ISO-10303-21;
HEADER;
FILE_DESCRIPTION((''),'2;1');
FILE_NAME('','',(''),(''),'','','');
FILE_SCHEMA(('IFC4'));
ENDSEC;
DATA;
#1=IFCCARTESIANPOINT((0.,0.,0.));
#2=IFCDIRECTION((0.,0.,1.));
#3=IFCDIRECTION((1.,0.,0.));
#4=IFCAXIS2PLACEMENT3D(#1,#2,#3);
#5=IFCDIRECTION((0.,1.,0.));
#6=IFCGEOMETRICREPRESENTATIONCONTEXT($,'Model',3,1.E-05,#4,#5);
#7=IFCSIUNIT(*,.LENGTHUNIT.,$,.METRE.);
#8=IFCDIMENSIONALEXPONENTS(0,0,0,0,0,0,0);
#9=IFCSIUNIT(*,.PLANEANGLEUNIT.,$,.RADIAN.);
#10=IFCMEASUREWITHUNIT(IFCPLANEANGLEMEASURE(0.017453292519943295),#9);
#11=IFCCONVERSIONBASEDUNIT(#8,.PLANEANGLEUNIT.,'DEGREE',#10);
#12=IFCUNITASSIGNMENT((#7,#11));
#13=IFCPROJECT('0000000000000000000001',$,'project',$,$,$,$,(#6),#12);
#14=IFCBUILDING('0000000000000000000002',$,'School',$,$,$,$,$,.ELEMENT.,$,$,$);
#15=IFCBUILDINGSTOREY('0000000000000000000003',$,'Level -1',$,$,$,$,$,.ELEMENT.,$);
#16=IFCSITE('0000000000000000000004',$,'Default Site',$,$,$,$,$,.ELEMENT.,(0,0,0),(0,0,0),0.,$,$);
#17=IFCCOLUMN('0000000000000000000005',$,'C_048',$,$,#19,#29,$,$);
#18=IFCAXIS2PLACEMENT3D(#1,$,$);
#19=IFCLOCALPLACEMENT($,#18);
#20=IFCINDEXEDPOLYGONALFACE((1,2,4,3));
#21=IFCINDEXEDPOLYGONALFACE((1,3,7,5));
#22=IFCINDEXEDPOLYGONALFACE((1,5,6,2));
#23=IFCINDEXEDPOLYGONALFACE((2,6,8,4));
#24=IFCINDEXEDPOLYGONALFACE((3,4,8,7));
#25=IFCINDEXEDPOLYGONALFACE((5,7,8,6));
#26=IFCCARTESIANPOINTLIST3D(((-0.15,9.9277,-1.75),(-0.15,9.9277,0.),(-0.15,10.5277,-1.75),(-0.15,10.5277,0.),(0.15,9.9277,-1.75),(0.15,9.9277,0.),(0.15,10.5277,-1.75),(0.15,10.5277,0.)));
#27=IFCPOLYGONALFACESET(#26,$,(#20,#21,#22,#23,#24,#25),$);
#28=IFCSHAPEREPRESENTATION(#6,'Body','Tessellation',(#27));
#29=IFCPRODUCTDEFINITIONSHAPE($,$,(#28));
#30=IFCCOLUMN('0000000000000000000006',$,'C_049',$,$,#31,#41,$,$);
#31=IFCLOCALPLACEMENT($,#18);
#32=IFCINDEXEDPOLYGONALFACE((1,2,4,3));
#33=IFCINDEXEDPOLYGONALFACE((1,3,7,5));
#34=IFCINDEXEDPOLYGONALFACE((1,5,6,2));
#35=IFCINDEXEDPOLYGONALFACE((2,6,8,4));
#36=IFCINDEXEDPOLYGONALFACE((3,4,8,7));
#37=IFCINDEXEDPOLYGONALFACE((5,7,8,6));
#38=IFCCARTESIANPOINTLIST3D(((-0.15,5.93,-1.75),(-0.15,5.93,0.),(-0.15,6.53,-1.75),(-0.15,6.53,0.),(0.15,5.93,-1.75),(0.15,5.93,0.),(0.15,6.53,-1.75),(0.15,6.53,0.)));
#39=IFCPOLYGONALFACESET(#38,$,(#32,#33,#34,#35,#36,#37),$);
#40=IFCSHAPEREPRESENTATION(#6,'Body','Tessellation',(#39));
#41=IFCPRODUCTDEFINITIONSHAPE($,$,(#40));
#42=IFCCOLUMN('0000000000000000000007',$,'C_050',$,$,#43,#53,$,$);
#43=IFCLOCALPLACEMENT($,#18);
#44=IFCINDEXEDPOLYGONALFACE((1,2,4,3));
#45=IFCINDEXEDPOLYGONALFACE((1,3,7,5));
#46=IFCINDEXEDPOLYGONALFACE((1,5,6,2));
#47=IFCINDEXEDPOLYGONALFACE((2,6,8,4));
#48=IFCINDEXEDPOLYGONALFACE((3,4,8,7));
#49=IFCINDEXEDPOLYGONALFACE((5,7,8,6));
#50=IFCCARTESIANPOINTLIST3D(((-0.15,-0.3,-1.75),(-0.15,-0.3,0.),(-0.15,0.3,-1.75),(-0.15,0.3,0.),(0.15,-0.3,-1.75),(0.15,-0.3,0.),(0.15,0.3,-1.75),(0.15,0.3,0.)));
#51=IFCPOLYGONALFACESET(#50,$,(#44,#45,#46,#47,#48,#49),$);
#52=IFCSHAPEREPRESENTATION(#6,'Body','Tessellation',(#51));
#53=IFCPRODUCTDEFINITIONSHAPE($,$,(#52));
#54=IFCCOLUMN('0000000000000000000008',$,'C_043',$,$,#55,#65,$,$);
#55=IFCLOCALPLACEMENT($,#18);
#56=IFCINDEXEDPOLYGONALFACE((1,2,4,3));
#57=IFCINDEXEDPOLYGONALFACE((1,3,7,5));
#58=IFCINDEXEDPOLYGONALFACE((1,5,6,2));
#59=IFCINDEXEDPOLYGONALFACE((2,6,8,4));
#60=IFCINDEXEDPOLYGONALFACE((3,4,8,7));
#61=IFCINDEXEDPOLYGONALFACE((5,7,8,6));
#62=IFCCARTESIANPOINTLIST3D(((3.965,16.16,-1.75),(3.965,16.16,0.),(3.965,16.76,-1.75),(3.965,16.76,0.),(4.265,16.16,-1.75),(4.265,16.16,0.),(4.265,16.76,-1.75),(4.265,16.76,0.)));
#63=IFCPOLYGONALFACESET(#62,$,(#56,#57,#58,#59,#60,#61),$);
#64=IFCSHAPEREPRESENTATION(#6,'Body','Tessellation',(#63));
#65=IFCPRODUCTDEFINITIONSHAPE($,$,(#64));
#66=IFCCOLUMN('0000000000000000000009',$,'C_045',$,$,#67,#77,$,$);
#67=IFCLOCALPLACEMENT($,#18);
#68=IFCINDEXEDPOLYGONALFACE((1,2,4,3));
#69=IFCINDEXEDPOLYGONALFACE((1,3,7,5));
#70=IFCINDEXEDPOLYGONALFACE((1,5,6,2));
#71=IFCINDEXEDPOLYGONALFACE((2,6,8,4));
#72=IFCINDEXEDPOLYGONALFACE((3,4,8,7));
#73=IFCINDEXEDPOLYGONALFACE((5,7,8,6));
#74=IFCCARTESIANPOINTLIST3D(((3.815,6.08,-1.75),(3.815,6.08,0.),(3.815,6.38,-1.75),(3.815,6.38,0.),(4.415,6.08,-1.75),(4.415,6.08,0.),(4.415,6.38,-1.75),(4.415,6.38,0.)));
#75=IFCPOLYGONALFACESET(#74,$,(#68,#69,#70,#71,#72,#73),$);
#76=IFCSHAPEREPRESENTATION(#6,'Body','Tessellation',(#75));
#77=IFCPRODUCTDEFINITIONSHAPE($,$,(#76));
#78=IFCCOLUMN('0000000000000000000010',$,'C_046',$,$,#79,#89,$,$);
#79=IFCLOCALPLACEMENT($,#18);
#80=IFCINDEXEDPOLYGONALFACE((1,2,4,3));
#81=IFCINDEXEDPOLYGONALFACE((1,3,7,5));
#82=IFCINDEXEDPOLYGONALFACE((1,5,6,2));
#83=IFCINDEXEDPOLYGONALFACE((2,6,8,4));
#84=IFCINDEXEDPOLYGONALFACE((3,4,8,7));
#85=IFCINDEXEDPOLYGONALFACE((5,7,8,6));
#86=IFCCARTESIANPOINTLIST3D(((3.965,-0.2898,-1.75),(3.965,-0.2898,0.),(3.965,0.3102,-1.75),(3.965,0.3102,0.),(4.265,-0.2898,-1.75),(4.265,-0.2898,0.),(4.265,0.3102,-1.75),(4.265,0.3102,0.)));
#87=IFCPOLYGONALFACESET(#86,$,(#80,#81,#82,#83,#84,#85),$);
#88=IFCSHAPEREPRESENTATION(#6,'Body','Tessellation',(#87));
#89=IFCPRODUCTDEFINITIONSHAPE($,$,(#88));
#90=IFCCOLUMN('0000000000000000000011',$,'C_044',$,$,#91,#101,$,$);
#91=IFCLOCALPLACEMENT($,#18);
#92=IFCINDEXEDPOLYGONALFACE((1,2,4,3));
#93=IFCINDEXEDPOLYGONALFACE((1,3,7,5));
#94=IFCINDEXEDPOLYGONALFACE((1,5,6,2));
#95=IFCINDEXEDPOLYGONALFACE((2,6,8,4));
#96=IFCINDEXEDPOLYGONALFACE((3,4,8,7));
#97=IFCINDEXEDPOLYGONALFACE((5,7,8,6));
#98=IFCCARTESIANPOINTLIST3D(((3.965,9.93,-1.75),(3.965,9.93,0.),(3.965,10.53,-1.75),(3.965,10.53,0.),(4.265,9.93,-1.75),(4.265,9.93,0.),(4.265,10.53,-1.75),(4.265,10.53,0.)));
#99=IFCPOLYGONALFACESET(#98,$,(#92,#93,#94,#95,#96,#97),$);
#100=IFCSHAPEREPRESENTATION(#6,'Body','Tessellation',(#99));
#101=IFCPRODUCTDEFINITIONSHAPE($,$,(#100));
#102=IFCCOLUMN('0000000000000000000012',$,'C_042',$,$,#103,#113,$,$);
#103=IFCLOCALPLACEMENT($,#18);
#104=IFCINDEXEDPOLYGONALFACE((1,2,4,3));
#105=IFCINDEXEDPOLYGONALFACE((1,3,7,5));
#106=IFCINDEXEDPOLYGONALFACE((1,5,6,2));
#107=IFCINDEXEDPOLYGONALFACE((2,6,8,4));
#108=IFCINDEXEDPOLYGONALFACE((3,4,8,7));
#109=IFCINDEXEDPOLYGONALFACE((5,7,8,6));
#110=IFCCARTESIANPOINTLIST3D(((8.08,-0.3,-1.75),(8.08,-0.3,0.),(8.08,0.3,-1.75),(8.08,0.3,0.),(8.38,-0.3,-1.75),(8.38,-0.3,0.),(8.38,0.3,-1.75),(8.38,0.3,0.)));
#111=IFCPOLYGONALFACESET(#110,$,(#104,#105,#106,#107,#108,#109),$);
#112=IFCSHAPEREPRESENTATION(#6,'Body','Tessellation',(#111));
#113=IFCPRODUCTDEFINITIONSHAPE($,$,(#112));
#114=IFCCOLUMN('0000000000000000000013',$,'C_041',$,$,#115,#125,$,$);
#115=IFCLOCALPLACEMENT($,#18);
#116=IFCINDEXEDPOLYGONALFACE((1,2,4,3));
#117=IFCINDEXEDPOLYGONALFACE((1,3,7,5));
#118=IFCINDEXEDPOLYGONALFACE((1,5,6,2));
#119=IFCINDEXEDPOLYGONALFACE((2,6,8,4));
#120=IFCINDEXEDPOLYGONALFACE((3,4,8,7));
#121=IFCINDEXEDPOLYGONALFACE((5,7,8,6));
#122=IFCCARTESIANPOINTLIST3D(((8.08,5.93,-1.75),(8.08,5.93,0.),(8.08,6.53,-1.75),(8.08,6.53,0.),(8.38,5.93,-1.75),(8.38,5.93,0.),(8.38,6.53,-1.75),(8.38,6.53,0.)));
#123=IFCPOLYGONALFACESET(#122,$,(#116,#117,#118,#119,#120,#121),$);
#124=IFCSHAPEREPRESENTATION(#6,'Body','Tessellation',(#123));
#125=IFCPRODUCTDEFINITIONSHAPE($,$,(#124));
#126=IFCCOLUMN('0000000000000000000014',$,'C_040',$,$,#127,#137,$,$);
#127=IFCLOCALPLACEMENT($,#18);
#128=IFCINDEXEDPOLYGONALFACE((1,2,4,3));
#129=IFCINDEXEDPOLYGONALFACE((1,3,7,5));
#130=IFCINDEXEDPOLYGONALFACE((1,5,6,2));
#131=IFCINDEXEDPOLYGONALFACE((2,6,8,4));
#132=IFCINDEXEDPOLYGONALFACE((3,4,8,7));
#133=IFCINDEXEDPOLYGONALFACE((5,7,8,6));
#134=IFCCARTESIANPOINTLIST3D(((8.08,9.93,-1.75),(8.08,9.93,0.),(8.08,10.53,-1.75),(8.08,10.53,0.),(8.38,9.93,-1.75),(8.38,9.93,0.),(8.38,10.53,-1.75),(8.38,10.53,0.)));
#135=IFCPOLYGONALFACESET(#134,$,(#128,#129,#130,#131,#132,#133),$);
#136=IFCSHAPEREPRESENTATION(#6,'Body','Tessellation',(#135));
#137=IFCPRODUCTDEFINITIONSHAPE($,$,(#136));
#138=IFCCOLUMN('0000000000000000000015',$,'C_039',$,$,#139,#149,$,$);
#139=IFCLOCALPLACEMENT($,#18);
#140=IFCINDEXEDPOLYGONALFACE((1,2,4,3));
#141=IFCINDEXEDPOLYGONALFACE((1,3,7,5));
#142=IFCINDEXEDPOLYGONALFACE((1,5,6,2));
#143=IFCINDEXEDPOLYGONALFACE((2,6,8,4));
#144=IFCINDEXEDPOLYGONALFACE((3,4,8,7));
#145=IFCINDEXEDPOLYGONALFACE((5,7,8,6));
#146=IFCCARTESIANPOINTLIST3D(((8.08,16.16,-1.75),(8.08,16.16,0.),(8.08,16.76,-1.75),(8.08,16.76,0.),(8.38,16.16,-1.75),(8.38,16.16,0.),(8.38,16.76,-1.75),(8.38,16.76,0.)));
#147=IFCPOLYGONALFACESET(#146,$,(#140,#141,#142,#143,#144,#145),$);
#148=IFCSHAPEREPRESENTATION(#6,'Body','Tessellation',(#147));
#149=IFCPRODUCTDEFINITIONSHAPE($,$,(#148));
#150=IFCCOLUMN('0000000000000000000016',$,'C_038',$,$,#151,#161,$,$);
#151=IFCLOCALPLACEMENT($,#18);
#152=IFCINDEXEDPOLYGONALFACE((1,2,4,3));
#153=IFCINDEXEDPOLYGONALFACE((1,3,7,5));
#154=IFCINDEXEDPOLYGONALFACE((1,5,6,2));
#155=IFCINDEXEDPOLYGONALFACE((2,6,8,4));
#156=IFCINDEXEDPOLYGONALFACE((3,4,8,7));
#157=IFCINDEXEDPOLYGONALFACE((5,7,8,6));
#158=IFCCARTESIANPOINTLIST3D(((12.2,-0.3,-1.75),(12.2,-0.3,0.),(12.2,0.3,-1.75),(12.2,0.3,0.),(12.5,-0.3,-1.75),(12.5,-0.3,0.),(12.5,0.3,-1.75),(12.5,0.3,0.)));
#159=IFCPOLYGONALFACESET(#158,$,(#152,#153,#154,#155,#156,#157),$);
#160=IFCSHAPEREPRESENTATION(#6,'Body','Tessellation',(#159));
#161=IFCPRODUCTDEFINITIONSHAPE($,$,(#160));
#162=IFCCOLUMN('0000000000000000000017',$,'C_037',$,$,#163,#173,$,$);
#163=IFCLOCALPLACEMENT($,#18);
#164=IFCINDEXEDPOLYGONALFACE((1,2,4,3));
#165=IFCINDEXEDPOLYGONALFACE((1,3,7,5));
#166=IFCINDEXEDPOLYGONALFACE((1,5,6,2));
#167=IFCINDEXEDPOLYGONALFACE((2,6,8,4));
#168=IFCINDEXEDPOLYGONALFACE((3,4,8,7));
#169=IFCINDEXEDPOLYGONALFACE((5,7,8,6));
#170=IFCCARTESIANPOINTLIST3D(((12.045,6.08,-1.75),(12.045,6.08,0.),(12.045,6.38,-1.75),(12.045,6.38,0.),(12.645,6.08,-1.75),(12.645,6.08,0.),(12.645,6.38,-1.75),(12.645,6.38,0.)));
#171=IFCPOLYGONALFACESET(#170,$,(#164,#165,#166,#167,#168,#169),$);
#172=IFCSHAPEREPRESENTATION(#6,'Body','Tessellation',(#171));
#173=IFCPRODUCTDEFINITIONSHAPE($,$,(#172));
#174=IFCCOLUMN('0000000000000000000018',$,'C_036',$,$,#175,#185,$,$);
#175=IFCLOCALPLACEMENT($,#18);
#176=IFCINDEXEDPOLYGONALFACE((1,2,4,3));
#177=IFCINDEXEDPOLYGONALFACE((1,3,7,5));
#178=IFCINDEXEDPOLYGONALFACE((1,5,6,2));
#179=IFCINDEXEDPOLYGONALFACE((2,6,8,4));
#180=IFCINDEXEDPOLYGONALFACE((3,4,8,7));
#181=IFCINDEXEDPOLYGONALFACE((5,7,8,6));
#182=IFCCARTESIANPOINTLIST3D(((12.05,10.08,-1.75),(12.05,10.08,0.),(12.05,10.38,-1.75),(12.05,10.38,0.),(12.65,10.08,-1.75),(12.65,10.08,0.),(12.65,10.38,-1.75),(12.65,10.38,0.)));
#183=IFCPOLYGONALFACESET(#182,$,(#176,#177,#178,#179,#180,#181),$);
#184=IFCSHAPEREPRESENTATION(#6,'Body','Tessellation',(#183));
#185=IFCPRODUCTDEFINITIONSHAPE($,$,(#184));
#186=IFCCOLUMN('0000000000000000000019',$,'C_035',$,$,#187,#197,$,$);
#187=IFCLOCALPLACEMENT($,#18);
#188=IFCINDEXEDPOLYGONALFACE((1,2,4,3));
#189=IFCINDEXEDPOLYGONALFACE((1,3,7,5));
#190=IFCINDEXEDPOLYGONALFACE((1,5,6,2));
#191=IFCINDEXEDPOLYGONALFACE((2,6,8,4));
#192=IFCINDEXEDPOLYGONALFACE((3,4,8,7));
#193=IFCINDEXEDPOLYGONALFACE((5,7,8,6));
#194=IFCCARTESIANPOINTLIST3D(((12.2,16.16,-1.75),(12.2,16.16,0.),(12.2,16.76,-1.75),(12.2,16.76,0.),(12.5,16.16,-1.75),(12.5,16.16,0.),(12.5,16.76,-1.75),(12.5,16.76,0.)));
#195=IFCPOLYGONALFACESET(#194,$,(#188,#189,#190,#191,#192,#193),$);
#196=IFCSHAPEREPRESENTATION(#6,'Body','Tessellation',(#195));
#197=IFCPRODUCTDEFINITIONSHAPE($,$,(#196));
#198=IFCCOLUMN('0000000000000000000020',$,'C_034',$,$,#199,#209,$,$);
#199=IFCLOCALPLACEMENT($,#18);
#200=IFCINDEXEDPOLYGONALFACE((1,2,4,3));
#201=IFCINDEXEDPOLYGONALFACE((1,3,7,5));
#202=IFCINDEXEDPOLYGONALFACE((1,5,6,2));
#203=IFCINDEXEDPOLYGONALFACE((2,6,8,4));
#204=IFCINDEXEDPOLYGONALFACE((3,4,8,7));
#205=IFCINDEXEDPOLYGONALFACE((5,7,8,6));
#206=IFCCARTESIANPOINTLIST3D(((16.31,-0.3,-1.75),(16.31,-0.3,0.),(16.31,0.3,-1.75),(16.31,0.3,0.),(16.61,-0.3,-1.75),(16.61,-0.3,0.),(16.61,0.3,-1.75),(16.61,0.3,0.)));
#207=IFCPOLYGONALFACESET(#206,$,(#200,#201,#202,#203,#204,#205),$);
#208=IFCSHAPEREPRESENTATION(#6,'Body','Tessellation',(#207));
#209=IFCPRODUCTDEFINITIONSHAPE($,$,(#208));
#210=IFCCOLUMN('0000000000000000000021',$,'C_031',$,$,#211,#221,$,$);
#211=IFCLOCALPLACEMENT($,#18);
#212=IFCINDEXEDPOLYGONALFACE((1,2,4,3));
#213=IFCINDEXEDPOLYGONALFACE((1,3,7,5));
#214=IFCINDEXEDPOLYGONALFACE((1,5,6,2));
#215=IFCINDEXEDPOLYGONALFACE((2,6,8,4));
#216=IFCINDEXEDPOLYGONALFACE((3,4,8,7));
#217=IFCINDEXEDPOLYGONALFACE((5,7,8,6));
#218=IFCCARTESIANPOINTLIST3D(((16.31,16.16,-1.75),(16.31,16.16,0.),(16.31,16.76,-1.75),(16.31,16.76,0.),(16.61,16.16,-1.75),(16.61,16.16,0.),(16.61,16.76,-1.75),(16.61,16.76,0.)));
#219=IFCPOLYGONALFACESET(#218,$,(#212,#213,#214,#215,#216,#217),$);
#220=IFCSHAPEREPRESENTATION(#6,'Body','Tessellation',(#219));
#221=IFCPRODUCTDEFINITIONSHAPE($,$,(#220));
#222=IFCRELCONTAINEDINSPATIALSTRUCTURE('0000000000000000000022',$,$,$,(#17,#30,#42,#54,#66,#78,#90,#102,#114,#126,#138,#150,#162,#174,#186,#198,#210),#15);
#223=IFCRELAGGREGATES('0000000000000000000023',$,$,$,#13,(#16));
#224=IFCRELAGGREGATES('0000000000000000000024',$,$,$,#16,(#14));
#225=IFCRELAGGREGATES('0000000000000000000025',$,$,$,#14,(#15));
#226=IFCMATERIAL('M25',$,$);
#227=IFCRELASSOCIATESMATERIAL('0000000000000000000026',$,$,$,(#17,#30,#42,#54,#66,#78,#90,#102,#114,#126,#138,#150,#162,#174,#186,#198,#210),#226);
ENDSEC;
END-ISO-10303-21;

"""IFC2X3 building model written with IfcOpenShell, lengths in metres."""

from ifc_helpers import new_model, entity, si_unit, converted_unit, direction, frame, frame_2d, origin_with_axes, place, context, project, spatial, rectangle, extrude, material, element, save


model = new_model("IFC2X3")

# Units and contexts
model_context = context("Model", 3, precision=1e-05, world=origin_with_axes(), true_north=direction((0.0, 1.0, 0.0)))
ifc_project = project(units=[si_unit("LENGTHUNIT", "METRE"), converted_unit("PLANEANGLEUNIT", "DEGREE", entity("IfcPlaneAngleMeasure", 0.017453292519943295), si_unit("PLANEANGLEUNIT", "RADIAN"), dimensions=[0, 0, 0, 0, 0, 0, 0])], contexts=[model_context])

# Site, building, storey
site = spatial("IfcSite", under=ifc_project, Name="Default Site", CompositionType="ELEMENT", RefLatitude=(0, 0, 0), RefLongitude=(0, 0, 0), RefElevation=0.0)
building = spatial("IfcBuilding", under=site, Name="School", CompositionType="ELEMENT")
storey = spatial("IfcBuildingStorey", under=building, Name="Level -1", CompositionType="ELEMENT")

# Columns
ifc_material = material(Name="M25")
placement = place(None, origin_with_axes())
element("IfcColumn", 1, at=placement, inside=storey, material=ifc_material, Name="C_048", context=model_context, shape_type="SweptSolid", body=[
    extrude(rectangle(XDim=0.3, YDim=0.6, at=frame_2d((0.0, 0.0), x_axis=(1.0, 0.0, 0.0))), frame((0.0, 10.2277, -1.75), z_axis=(0.0, 0.0, 1.0), x_axis=(1.0, 0.0, 0.0)), (0.0, 0.0, 1.0), 1.75),
])
element("IfcColumn", 2, at=placement, inside=storey, material=ifc_material, Name="C_049", context=model_context, shape_type="SweptSolid", body=[
    extrude(rectangle(XDim=0.3, YDim=0.6, at=frame_2d((0.0, 0.0), x_axis=(1.0, 0.0, 0.0))), frame((0.0, 6.23, -1.75), z_axis=(0.0, 0.0, 1.0), x_axis=(1.0, 0.0, 0.0)), (0.0, 0.0, 1.0), 1.75),
])
element("IfcColumn", 3, at=placement, inside=storey, material=ifc_material, Name="C_050", context=model_context, shape_type="SweptSolid", body=[
    extrude(rectangle(XDim=0.3, YDim=0.6, at=frame_2d((0.0, 0.0), x_axis=(1.0, 0.0, 0.0))), frame((0.0, 0.0, -1.75), z_axis=(0.0, 0.0, 1.0), x_axis=(1.0, 0.0, 0.0)), (0.0, 0.0, 1.0), 1.75),
])
element("IfcColumn", 4, at=placement, inside=storey, material=ifc_material, Name="C_043", context=model_context, shape_type="SweptSolid", body=[
    extrude(rectangle(XDim=0.3, YDim=0.6, at=frame_2d((0.0, 0.0), x_axis=(1.0, 0.0, 0.0))), frame((4.115, 16.46, -1.75), z_axis=(0.0, 0.0, 1.0), x_axis=(1.0, 0.0, 0.0)), (0.0, 0.0, 1.0), 1.75),
])
element("IfcColumn", 5, at=placement, inside=storey, material=ifc_material, Name="C_045", context=model_context, shape_type="SweptSolid", body=[
    extrude(rectangle(XDim=0.6, YDim=0.3, at=frame_2d((0.0, 0.0), x_axis=(1.0, 0.0, 0.0))), frame((4.115, 6.23, -1.75), z_axis=(0.0, 0.0, 1.0), x_axis=(1.0, 0.0, 0.0)), (0.0, 0.0, 1.0), 1.75),
])
element("IfcColumn", 6, at=placement, inside=storey, material=ifc_material, Name="C_046", context=model_context, shape_type="SweptSolid", body=[
    extrude(rectangle(XDim=0.3, YDim=0.6, at=frame_2d((0.0, 0.0), x_axis=(1.0, 0.0, 0.0))), frame((4.115, 0.0102, -1.75), z_axis=(0.0, 0.0, 1.0), x_axis=(1.0, 0.0, 0.0)), (0.0, 0.0, 1.0), 1.75),
])
element("IfcColumn", 7, at=placement, inside=storey, material=ifc_material, Name="C_044", context=model_context, shape_type="SweptSolid", body=[
    extrude(rectangle(XDim=0.3, YDim=0.6, at=frame_2d((0.0, 0.0), x_axis=(1.0, 0.0, 0.0))), frame((4.115, 10.23, -1.75), z_axis=(0.0, 0.0, 1.0), x_axis=(1.0, 0.0, 0.0)), (0.0, 0.0, 1.0), 1.75),
])
element("IfcColumn", 8, at=placement, inside=storey, material=ifc_material, Name="C_042", context=model_context, shape_type="SweptSolid", body=[
    extrude(rectangle(XDim=0.3, YDim=0.6, at=frame_2d((0.0, 0.0), x_axis=(1.0, 0.0, 0.0))), frame((8.23, 0.0, -1.75), z_axis=(0.0, 0.0, 1.0), x_axis=(1.0, 0.0, 0.0)), (0.0, 0.0, 1.0), 1.75),
])
element("IfcColumn", 9, at=placement, inside=storey, material=ifc_material, Name="C_041", context=model_context, shape_type="SweptSolid", body=[
    extrude(rectangle(XDim=0.3, YDim=0.6, at=frame_2d((0.0, 0.0), x_axis=(1.0, 0.0, 0.0))), frame((8.23, 6.23, -1.75), z_axis=(0.0, 0.0, 1.0), x_axis=(1.0, 0.0, 0.0)), (0.0, 0.0, 1.0), 1.75),
])
element("IfcColumn", 10, at=placement, inside=storey, material=ifc_material, Name="C_040", context=model_context, shape_type="SweptSolid", body=[
    extrude(rectangle(XDim=0.3, YDim=0.6, at=frame_2d((0.0, 0.0), x_axis=(1.0, 0.0, 0.0))), frame((8.23, 10.23, -1.75), z_axis=(0.0, 0.0, 1.0), x_axis=(1.0, 0.0, 0.0)), (0.0, 0.0, 1.0), 1.75),
])
element("IfcColumn", 11, at=placement, inside=storey, material=ifc_material, Name="C_039", context=model_context, shape_type="SweptSolid", body=[
    extrude(rectangle(XDim=0.3, YDim=0.6, at=frame_2d((0.0, 0.0), x_axis=(1.0, 0.0, 0.0))), frame((8.23, 16.46, -1.75), z_axis=(0.0, 0.0, 1.0), x_axis=(1.0, 0.0, 0.0)), (0.0, 0.0, 1.0), 1.75),
])
element("IfcColumn", 12, at=placement, inside=storey, material=ifc_material, Name="C_038", context=model_context, shape_type="SweptSolid", body=[
    extrude(rectangle(XDim=0.3, YDim=0.6, at=frame_2d((0.0, 0.0), x_axis=(1.0, 0.0, 0.0))), frame((12.35, 0.0, -1.75), z_axis=(0.0, 0.0, 1.0), x_axis=(1.0, 0.0, 0.0)), (0.0, 0.0, 1.0), 1.75),
])
element("IfcColumn", 13, at=placement, inside=storey, material=ifc_material, Name="C_037", context=model_context, shape_type="SweptSolid", body=[
    extrude(rectangle(XDim=0.6, YDim=0.3, at=frame_2d((0.0, 0.0), x_axis=(1.0, 0.0, 0.0))), frame((12.345, 6.23, -1.75), z_axis=(0.0, 0.0, 1.0), x_axis=(1.0, 0.0, 0.0)), (0.0, 0.0, 1.0), 1.75),
])
element("IfcColumn", 14, at=placement, inside=storey, material=ifc_material, Name="C_036", context=model_context, shape_type="SweptSolid", body=[
    extrude(rectangle(XDim=0.6, YDim=0.3, at=frame_2d((0.0, 0.0), x_axis=(1.0, 0.0, 0.0))), frame((12.35, 10.23, -1.75), z_axis=(0.0, 0.0, 1.0), x_axis=(1.0, 0.0, 0.0)), (0.0, 0.0, 1.0), 1.75),
])
element("IfcColumn", 15, at=placement, inside=storey, material=ifc_material, Name="C_035", context=model_context, shape_type="SweptSolid", body=[
    extrude(rectangle(XDim=0.3, YDim=0.6, at=frame_2d((0.0, 0.0), x_axis=(1.0, 0.0, 0.0))), frame((12.35, 16.46, -1.75), z_axis=(0.0, 0.0, 1.0), x_axis=(1.0, 0.0, 0.0)), (0.0, 0.0, 1.0), 1.75),
])
element("IfcColumn", 16, at=placement, inside=storey, material=ifc_material, Name="C_034", context=model_context, shape_type="SweptSolid", body=[
    extrude(rectangle(XDim=0.3, YDim=0.6, at=frame_2d((0.0, 0.0), x_axis=(1.0, 0.0, 0.0))), frame((16.46, 0.0, -1.75), z_axis=(0.0, 0.0, 1.0), x_axis=(1.0, 0.0, 0.0)), (0.0, 0.0, 1.0), 1.75),
])
element("IfcColumn", 17, at=placement, inside=storey, material=ifc_material, Name="C_031", context=model_context, shape_type="SweptSolid", body=[
    extrude(rectangle(XDim=0.3, YDim=0.6, at=frame_2d((0.0, 0.0), x_axis=(1.0, 0.0, 0.0))), frame((16.46, 16.46, -1.75), z_axis=(0.0, 0.0, 1.0), x_axis=(1.0, 0.0, 0.0)), (0.0, 0.0, 1.0), 1.75),
])

save(model, "model.ifc")
